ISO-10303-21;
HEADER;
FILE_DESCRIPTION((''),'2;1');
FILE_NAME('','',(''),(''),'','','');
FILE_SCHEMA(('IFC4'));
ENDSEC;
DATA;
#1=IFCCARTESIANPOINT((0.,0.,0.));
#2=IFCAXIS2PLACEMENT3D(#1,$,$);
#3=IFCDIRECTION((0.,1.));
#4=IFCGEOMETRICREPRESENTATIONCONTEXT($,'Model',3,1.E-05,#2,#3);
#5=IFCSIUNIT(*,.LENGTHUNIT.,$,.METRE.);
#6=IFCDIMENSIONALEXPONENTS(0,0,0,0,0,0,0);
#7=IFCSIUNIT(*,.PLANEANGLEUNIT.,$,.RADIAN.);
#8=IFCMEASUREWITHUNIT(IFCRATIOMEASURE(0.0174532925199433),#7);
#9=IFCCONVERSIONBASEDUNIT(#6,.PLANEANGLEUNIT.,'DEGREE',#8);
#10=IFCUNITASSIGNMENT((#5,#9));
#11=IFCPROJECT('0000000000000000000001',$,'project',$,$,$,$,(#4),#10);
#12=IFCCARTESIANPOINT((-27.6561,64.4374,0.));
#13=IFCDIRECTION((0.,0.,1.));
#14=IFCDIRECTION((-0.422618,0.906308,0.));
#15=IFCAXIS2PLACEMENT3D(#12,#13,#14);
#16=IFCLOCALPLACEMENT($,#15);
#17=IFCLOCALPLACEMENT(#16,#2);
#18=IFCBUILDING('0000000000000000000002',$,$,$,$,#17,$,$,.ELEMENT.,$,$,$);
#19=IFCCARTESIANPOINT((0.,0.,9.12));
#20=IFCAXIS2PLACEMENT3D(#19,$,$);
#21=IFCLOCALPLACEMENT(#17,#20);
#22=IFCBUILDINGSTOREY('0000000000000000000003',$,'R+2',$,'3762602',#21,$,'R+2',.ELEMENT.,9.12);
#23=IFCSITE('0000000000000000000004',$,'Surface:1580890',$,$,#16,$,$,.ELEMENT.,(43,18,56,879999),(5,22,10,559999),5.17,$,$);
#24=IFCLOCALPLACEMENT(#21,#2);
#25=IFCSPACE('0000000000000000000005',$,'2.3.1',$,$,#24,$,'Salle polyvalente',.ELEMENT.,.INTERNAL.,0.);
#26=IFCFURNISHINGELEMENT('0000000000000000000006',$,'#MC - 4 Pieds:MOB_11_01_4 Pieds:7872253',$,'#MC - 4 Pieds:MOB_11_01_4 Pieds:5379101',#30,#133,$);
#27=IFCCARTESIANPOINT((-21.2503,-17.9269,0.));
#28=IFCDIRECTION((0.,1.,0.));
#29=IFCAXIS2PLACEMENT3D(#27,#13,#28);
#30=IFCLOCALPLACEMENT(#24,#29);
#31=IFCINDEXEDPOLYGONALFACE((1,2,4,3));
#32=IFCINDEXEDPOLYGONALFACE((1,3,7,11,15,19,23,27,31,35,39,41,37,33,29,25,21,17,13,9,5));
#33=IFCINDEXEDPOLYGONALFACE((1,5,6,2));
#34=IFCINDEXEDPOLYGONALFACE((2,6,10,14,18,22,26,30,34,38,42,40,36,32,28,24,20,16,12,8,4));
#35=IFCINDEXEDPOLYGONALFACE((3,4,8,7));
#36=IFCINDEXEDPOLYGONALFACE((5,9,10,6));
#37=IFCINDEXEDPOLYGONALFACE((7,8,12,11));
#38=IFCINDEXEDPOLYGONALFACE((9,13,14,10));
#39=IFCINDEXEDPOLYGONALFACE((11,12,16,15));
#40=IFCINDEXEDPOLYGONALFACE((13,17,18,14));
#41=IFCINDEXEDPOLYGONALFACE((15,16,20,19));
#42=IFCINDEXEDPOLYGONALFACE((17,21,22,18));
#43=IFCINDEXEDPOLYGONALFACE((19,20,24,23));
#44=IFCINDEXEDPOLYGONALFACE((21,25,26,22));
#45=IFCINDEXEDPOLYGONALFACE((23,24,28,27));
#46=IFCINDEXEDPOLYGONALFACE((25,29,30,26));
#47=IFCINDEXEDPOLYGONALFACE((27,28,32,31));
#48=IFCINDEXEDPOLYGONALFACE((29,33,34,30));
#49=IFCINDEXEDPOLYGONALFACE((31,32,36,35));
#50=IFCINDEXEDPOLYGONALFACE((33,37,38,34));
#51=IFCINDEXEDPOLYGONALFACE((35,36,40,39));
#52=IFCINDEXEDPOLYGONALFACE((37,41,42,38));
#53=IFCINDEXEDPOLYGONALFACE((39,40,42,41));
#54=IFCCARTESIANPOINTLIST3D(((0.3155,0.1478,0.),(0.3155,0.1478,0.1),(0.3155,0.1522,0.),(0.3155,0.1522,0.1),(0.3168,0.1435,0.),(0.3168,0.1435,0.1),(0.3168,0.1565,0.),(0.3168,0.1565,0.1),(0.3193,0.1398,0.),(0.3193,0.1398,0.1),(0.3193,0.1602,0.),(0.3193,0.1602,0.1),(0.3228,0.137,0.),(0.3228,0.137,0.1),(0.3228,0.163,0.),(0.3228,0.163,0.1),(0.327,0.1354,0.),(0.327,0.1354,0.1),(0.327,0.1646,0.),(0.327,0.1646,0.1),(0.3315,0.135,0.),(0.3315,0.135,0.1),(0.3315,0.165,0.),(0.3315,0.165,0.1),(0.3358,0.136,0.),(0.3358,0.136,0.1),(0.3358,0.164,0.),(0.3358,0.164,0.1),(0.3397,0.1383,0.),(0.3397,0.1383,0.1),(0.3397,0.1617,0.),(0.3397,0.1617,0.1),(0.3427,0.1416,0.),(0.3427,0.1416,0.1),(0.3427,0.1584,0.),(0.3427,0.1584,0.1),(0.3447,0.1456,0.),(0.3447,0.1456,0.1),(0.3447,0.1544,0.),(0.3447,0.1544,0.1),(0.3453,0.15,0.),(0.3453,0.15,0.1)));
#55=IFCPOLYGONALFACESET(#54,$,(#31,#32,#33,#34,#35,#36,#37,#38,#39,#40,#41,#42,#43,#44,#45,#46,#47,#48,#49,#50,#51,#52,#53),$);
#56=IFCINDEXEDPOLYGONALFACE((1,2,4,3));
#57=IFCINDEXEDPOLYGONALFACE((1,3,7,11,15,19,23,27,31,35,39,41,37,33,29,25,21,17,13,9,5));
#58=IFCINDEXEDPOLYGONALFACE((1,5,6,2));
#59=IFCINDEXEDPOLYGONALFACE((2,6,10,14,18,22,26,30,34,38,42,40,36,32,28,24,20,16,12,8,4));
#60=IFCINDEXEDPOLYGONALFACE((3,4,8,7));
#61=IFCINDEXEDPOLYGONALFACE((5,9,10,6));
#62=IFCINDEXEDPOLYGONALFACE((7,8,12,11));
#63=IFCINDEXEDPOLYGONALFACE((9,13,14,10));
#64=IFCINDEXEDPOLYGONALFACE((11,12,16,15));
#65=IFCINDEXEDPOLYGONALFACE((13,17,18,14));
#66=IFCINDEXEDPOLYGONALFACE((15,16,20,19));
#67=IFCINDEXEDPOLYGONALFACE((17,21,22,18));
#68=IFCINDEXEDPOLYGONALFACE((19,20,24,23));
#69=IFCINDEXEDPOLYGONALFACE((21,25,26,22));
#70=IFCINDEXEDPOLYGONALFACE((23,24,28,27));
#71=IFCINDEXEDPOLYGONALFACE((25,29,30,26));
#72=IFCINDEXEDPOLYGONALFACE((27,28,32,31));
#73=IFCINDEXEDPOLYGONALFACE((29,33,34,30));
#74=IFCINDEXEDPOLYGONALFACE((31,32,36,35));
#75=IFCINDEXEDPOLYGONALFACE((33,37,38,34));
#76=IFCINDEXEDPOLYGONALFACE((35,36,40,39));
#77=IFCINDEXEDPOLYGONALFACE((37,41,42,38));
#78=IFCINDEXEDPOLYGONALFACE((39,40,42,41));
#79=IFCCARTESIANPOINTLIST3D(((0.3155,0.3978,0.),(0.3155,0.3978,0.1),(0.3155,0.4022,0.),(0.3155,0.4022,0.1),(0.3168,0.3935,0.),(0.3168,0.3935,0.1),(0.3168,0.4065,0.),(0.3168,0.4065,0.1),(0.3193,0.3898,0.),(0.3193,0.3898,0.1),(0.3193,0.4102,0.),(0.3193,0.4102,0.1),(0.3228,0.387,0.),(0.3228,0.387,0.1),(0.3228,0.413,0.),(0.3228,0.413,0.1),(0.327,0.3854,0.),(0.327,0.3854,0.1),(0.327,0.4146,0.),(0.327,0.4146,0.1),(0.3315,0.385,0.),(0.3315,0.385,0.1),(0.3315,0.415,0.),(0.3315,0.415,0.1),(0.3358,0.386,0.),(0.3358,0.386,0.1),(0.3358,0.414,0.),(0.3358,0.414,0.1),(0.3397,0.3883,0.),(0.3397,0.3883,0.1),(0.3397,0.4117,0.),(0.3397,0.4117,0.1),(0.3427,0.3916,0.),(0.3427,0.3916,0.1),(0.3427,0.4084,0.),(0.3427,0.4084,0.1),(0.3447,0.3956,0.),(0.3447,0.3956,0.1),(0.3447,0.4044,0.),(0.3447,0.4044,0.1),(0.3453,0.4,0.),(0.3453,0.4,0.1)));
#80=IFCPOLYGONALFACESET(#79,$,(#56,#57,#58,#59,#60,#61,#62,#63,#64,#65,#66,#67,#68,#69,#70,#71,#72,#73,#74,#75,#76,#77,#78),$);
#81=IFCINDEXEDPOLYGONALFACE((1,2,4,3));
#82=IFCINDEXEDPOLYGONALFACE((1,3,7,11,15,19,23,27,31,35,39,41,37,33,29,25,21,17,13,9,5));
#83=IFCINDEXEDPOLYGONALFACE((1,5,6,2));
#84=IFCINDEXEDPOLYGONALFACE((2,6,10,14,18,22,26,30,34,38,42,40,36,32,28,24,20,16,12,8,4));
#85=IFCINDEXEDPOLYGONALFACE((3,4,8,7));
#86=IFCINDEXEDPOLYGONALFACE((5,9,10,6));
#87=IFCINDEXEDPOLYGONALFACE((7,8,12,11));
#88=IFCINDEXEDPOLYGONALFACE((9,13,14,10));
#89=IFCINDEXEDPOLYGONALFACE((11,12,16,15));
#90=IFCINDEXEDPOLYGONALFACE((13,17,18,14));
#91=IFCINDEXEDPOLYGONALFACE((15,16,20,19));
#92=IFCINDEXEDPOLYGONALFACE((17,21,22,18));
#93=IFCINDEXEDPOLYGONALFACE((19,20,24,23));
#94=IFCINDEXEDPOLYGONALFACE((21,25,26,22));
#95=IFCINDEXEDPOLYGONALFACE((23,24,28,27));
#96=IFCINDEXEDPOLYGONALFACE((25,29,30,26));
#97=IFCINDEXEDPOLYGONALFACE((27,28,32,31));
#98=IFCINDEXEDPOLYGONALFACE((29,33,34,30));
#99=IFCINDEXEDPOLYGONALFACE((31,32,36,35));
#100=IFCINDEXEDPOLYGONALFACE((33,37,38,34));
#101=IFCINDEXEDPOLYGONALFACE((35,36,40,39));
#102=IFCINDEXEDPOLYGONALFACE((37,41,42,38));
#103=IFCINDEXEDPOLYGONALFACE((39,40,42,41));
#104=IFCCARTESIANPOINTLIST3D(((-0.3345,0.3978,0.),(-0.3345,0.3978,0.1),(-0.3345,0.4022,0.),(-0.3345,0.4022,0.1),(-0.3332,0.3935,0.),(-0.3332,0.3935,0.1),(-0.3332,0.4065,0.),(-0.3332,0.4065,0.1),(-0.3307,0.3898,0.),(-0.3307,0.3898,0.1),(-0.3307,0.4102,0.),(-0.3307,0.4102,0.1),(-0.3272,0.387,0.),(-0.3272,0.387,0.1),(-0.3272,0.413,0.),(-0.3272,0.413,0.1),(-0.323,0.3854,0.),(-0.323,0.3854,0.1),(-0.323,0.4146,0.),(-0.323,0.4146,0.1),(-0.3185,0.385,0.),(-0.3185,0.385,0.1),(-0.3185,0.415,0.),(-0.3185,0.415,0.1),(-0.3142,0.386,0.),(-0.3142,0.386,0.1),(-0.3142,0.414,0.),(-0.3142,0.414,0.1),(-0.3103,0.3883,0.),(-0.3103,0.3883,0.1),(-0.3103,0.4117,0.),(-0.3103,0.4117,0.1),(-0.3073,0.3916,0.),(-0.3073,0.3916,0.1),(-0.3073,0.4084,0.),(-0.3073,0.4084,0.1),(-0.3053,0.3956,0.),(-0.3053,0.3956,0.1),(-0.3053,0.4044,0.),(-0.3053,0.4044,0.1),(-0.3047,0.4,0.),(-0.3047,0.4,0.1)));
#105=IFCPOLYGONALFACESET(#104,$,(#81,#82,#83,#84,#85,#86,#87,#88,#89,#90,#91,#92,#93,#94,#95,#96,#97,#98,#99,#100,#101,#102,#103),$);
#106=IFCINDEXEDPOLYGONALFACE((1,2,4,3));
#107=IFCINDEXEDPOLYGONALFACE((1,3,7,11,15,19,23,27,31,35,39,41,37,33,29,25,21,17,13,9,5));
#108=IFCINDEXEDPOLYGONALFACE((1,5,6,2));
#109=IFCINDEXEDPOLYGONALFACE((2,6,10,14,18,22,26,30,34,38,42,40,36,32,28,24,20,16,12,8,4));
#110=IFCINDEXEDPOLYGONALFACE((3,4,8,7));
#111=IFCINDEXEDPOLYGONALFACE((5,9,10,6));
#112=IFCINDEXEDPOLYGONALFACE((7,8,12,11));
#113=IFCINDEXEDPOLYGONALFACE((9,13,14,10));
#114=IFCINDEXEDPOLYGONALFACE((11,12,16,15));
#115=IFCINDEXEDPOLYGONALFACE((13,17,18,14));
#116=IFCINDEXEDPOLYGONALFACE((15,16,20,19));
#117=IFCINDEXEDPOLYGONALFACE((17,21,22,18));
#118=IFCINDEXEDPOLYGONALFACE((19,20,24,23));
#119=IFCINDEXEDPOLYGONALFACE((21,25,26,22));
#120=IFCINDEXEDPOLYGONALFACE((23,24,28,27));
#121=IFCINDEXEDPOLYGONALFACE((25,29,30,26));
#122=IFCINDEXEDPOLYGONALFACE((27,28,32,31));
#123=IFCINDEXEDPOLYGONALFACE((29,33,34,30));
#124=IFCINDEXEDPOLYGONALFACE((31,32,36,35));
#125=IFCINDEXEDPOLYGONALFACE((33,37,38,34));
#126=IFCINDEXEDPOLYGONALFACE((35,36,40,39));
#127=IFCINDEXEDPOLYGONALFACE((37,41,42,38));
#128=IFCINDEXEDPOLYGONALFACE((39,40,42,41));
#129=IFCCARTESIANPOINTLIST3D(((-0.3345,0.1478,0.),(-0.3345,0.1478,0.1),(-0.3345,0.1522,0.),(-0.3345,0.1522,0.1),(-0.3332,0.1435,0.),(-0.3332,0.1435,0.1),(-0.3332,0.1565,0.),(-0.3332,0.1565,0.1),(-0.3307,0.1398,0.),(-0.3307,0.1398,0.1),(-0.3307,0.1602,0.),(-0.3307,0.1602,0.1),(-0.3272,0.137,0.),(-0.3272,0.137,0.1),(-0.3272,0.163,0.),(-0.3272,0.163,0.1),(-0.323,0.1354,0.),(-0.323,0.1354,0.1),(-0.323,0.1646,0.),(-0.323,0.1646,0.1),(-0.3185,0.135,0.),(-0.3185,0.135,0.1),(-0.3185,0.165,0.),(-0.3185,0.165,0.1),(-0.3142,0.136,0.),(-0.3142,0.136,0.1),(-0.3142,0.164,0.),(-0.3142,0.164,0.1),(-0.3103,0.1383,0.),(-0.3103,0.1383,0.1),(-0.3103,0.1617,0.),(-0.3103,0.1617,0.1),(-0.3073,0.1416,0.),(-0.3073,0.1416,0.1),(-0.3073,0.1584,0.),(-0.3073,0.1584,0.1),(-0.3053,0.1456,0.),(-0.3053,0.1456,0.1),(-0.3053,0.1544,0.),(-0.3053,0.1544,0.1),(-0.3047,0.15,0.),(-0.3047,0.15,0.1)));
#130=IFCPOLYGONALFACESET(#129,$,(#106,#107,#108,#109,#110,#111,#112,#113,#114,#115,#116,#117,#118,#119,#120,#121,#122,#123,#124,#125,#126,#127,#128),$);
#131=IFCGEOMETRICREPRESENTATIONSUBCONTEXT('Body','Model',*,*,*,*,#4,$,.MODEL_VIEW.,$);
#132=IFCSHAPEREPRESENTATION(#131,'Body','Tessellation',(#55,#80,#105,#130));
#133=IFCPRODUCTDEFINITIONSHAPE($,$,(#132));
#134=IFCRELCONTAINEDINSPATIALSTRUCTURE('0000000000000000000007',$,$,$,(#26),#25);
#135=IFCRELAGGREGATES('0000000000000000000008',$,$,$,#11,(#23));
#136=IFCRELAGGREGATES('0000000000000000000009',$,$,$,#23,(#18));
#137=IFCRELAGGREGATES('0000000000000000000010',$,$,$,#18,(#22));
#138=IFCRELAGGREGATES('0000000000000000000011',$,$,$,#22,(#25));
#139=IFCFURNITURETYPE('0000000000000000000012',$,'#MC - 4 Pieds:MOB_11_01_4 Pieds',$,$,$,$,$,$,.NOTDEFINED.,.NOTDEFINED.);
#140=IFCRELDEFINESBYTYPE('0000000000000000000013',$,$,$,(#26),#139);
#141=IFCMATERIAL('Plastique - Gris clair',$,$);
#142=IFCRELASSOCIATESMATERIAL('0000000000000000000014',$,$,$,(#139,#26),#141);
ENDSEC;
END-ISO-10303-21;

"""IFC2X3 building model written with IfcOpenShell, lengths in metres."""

from ifc_helpers import new_model, entity, si_unit, converted_unit, direction, frame, frame_2d, origin, origin_2d_with_axis, place, context, subcontext, project, spatial, circle, extrude, source, transform, mapped, material, type_object, type_shapes, element, save


model = new_model("IFC2X3")

# Units and contexts
model_context = context("Model", 3, precision=1e-05, world=origin(), true_north=direction((0.0, 1.0)))
body_context = subcontext(model_context, "Body", "Model", "MODEL_VIEW")
ifc_project = project(units=[si_unit("LENGTHUNIT", "METRE"), converted_unit("PLANEANGLEUNIT", "DEGREE", entity("IfcRatioMeasure", 0.0174532925199433), si_unit("PLANEANGLEUNIT", "RADIAN"), dimensions=[0, 0, 0, 0, 0, 0, 0])], contexts=[model_context])

# Site, building, storey
site_placement = place(None, frame((-27.6561, 64.4374, 0.0), z_axis=(0.0, 0.0, 1.0), x_axis=(-0.422618, 0.906308, 0.0)))
site = spatial("IfcSite", under=ifc_project, at=site_placement, Name="Surface:1580890", CompositionType="ELEMENT", RefLatitude=(43, 18, 56, 879999), RefLongitude=(5, 22, 10, 559999), RefElevation=5.17)
building_placement = place(site_placement, origin())
building = spatial("IfcBuilding", under=site, at=building_placement, CompositionType="ELEMENT")
storey_placement = place(building_placement, frame((0.0, 0.0, 9.12)))
storey = spatial("IfcBuildingStorey", under=building, at=storey_placement, Name="R+2", ObjectType="3762602", LongName="R+2", CompositionType="ELEMENT", Elevation=9.12)

# Shared definitions
space_placement = place(storey_placement, origin())
space = spatial("IfcSpace", under=storey, at=space_placement, Name="2.3.1", LongName="Salle polyvalente", CompositionType="ELEMENT", InteriorOrExteriorSpace="INTERNAL", ElevationWithFlooring=0.0)

# Furnishing element
ifc_material_1 = material(Name="Plastique - Gris clair")
furniture_type_1 = type_object("IfcFurnitureType", Name="#MC - 4 Pieds:MOB_11_01_4 Pieds", material=ifc_material_1)
shared_shape_1 = source(origin(), body_context, "Body", "SweptSolid", [
    extrude(circle(Radius=0.015, at=frame_2d((0.0, 0.0), x_axis=(1.0, 0.0))), frame((0.3303, 0.15, 0.0)), (0.0, 0.0, 1.0), 0.1),
    extrude(circle(Radius=0.015, at=frame_2d((0.0, 0.0), x_axis=(1.0, 0.0))), frame((0.3303, 0.4, 0.0)), (0.0, 0.0, 1.0), 0.1),
    extrude(circle(Radius=0.015, at=origin_2d_with_axis()), frame((-0.3197, 0.4, 0.0)), (0.0, 0.0, 1.0), 0.1),
    extrude(circle(Radius=0.015, at=frame_2d((0.0, 0.0), x_axis=(1.0, 0.0))), frame((-0.3197, 0.15, 0.0)), (0.0, 0.0, 1.0), 0.1),
])
type_shapes(furniture_type_1, [shared_shape_1])
for number, where, z_axis, x_axis, name in (
    (1, (-21.2503, -17.9269, 0.0), (0.0, 0.0, 1.0), (0.0, 1.0, 0.0), "#MC - 4 Pieds:MOB_11_01_4 Pieds:7872253"),
):
    element("IfcFurnishingElement", number, at=place(space_placement, frame(where, z_axis=z_axis, x_axis=x_axis)), inside=space, type_object=furniture_type_1, material=ifc_material_1, Name=name, ObjectType="#MC - 4 Pieds:MOB_11_01_4 Pieds:5379101", context=body_context, shape_type="MappedRepresentation", body=[
        mapped(shared_shape_1, transform((0.0, 0.0, 0.0), scale=1.0)),
    ])

save(model, "model.ifc")
